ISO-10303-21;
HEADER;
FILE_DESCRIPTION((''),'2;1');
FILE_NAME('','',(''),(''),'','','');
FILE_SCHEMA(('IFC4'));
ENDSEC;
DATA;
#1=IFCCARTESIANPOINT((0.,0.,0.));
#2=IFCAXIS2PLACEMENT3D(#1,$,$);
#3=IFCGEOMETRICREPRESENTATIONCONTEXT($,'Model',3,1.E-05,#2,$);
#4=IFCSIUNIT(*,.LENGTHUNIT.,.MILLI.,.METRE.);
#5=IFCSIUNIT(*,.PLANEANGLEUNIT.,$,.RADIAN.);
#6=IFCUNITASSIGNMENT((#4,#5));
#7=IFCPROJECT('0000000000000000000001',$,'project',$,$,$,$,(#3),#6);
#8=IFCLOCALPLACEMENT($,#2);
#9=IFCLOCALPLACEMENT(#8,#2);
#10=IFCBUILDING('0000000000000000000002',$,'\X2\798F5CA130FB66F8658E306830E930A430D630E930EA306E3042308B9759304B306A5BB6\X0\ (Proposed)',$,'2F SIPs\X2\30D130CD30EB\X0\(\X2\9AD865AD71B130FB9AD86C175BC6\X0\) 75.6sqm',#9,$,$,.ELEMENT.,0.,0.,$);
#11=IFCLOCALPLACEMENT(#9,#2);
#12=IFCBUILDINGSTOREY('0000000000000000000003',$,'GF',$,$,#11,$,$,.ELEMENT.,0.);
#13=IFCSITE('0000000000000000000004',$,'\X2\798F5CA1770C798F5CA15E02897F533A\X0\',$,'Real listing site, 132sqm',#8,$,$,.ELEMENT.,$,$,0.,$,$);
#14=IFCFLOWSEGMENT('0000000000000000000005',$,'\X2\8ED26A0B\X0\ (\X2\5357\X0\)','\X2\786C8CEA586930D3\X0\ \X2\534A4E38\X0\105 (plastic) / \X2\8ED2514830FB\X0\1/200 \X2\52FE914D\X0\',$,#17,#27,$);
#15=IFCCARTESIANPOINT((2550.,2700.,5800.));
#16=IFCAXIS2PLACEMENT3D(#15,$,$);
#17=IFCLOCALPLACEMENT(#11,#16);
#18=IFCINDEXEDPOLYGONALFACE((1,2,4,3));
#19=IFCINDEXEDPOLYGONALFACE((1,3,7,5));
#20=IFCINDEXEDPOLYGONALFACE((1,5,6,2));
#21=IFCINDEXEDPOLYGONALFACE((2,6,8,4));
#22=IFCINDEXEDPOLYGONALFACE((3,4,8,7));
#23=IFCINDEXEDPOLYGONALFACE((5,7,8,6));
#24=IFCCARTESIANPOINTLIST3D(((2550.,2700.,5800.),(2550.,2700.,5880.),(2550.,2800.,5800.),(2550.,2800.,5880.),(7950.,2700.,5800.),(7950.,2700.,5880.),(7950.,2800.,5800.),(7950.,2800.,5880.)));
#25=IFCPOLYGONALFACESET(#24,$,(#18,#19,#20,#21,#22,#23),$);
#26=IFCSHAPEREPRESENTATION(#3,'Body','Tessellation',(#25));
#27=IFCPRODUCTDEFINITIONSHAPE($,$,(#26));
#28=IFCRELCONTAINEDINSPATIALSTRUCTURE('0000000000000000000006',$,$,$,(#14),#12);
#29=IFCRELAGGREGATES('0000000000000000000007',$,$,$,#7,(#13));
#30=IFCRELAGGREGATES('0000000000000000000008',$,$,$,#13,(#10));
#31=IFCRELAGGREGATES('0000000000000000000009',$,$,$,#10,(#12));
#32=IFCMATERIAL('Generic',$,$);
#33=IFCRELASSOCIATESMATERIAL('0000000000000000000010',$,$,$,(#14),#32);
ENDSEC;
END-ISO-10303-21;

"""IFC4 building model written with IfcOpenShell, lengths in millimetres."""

from ifc_helpers import new_model, si_unit, frame, frame_2d, origin, place, context, project, spatial, rectangle, extrude, material, element, save


model = new_model("IFC4")

# Units and contexts
model_context = context("Model", 3, precision=1e-05, world=origin())
ifc_project = project(units=[si_unit("LENGTHUNIT", "METRE", prefix="MILLI"), si_unit("PLANEANGLEUNIT", "RADIAN")], contexts=[model_context])

# Site, building, storey
site_placement = place(None, origin())
site = spatial("IfcSite", under=ifc_project, at=site_placement, Name="福岡県福岡市西区", ObjectType="Real listing site, 132sqm", CompositionType="ELEMENT", RefElevation=0.0)
building_placement = place(site_placement, origin())
building = spatial("IfcBuilding", under=site, at=building_placement, Name="福岡・書斎とライブラリのある静かな家 (Proposed)", ObjectType="2F SIPsパネル(高断熱・高気密) 75.6sqm", CompositionType="ELEMENT", ElevationOfRefHeight=0.0, ElevationOfTerrain=0.0)
storey_placement = place(building_placement, origin())
storey = spatial("IfcBuildingStorey", under=building, at=storey_placement, Name="GF", CompositionType="ELEMENT", Elevation=0.0)

# Flow segment
ifc_material_1 = material(Name="Generic")
flow_segment_placement = place(storey_placement, frame((2550.0, 2700.0, 5800.0)))
element("IfcFlowSegment", 1, at=flow_segment_placement, inside=storey, material=ifc_material_1, Name="軒樋 (南)", Description="硬質塩ビ 半丸105 (plastic) / 軒先・1/200 勾配", context=model_context, shape_type="SweptSolid", body=[
    extrude(rectangle(XDim=5400.0, YDim=100.0, at=frame_2d((2700.0, 50.0))), frame((2550.0, 2700.0, 5800.0)), (0.0, 0.0, 1.0), 80.0),
])

save(model, "model.ifc")
